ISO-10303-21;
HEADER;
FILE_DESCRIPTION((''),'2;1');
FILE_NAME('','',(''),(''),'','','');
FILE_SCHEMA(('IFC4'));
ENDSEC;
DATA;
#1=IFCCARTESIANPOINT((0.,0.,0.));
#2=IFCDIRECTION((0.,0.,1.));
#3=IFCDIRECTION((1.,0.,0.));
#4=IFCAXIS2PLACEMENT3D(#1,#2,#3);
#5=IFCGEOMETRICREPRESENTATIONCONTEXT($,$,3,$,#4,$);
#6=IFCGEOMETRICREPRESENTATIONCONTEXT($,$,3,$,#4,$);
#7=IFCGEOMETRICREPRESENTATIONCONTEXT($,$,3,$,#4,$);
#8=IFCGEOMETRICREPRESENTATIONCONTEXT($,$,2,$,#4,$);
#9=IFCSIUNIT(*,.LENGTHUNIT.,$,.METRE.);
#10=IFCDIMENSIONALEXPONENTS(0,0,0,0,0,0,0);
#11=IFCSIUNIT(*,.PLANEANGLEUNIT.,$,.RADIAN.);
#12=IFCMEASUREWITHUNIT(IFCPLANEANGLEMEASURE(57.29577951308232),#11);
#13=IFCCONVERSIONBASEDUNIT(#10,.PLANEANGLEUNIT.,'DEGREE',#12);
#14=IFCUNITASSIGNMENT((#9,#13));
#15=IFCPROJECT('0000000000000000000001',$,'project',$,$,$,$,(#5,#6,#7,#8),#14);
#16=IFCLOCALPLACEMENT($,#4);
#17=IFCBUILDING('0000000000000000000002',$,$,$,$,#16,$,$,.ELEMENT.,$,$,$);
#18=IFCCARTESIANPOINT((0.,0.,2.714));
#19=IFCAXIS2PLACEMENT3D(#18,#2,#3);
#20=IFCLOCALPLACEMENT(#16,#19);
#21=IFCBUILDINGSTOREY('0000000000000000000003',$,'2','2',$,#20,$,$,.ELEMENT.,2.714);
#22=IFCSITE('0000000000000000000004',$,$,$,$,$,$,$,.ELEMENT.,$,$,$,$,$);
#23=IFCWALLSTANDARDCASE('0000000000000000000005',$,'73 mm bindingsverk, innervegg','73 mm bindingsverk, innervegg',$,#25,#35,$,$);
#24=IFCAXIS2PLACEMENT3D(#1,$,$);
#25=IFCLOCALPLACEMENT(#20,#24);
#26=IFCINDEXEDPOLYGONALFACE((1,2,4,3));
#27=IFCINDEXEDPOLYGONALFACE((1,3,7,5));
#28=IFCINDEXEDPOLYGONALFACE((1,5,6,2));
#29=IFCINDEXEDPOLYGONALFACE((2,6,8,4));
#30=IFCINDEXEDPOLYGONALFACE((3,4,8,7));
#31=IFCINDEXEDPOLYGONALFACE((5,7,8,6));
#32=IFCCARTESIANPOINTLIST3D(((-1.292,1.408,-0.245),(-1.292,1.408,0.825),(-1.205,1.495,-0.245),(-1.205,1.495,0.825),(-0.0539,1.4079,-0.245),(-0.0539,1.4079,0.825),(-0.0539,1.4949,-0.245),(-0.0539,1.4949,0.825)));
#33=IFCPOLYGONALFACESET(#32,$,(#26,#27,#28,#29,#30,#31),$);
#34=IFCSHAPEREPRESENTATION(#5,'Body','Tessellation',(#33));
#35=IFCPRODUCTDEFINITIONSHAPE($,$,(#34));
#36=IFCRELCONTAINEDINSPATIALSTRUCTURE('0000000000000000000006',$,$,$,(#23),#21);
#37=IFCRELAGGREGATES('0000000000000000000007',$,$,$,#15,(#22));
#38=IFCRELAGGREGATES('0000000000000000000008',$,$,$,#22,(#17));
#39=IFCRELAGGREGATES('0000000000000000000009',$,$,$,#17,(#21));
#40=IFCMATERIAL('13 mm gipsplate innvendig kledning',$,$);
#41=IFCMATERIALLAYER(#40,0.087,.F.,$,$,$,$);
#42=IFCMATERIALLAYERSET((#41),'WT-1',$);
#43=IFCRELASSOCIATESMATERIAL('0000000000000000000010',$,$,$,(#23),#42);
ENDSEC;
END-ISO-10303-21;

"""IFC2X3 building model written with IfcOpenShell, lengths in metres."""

from ifc_helpers import new_model, entity, si_unit, converted_unit, frame, origin_with_axes, place, context, project, spatial, polyline, outline, extrude, material, layer, layer_set, layer_usage, element, save


model = new_model("IFC2X3")

# Units and contexts
context_of_model_1 = context(None, 3, world=origin_with_axes())
context_of_model_2 = context(None, 3, world=origin_with_axes())
context_of_model_3 = context(None, 3, world=origin_with_axes())
context_of_model_4 = context(None, 2, world=origin_with_axes())
ifc_project = project(units=[si_unit("LENGTHUNIT", "METRE"), converted_unit("PLANEANGLEUNIT", "DEGREE", entity("IfcPlaneAngleMeasure", 57.29577951308232), si_unit("PLANEANGLEUNIT", "RADIAN"), dimensions=[0, 0, 0, 0, 0, 0, 0])], contexts=[context_of_model_1, context_of_model_2, context_of_model_3, context_of_model_4])

# Site, building, storey
site = spatial("IfcSite", under=ifc_project, CompositionType="ELEMENT")
building_placement = place(None, origin_with_axes())
building = spatial("IfcBuilding", under=site, at=building_placement, CompositionType="ELEMENT")
storey_placement = place(building_placement, frame((0.0, 0.0, 2.714), z_axis=(0.0, 0.0, 1.0), x_axis=(1.0, 0.0, 0.0)))
storey = spatial("IfcBuildingStorey", under=building, at=storey_placement, Name="2", Description="2", CompositionType="ELEMENT", Elevation=2.714)

# Wall
ifc_material_1 = material(Name="13 mm gipsplate innvendig kledning")
ifc_layer_1 = layer(ifc_material_1, 0.087, ventilated=False)
ifc_layer_set_1 = layer_set([ifc_layer_1], Name="WT-1")
ifc_layer_usage_1 = layer_usage(ifc_layer_set_1, "AXIS2", "POSITIVE", 0.0)
wall_1_placement = place(storey_placement, frame((-1.292, 1.408, -0.245), z_axis=(0.0, 0.0, 1.0), x_axis=(1.0, 0.0, 0.0)))
element("IfcWallStandardCase", 1, at=wall_1_placement, inside=storey, material=ifc_layer_usage_1, Name="73 mm bindingsverk, innervegg", Description="73 mm bindingsverk, innervegg", context=context_of_model_1, shape_type="SweptSolid", body=[
    extrude(outline(polyline([(0.0, 0.0), (1.2381, 0.0), (1.2381, 0.087), (0.087, 0.087), (0.0, 0.0)])), frame((0.0, 0.0, 0.0), z_axis=(0.0, 0.0, 1.0), x_axis=(1.0, -0.000073, 0.0)), (0.0, 0.0, 1.0), 1.07),
])

save(model, "model.ifc")
